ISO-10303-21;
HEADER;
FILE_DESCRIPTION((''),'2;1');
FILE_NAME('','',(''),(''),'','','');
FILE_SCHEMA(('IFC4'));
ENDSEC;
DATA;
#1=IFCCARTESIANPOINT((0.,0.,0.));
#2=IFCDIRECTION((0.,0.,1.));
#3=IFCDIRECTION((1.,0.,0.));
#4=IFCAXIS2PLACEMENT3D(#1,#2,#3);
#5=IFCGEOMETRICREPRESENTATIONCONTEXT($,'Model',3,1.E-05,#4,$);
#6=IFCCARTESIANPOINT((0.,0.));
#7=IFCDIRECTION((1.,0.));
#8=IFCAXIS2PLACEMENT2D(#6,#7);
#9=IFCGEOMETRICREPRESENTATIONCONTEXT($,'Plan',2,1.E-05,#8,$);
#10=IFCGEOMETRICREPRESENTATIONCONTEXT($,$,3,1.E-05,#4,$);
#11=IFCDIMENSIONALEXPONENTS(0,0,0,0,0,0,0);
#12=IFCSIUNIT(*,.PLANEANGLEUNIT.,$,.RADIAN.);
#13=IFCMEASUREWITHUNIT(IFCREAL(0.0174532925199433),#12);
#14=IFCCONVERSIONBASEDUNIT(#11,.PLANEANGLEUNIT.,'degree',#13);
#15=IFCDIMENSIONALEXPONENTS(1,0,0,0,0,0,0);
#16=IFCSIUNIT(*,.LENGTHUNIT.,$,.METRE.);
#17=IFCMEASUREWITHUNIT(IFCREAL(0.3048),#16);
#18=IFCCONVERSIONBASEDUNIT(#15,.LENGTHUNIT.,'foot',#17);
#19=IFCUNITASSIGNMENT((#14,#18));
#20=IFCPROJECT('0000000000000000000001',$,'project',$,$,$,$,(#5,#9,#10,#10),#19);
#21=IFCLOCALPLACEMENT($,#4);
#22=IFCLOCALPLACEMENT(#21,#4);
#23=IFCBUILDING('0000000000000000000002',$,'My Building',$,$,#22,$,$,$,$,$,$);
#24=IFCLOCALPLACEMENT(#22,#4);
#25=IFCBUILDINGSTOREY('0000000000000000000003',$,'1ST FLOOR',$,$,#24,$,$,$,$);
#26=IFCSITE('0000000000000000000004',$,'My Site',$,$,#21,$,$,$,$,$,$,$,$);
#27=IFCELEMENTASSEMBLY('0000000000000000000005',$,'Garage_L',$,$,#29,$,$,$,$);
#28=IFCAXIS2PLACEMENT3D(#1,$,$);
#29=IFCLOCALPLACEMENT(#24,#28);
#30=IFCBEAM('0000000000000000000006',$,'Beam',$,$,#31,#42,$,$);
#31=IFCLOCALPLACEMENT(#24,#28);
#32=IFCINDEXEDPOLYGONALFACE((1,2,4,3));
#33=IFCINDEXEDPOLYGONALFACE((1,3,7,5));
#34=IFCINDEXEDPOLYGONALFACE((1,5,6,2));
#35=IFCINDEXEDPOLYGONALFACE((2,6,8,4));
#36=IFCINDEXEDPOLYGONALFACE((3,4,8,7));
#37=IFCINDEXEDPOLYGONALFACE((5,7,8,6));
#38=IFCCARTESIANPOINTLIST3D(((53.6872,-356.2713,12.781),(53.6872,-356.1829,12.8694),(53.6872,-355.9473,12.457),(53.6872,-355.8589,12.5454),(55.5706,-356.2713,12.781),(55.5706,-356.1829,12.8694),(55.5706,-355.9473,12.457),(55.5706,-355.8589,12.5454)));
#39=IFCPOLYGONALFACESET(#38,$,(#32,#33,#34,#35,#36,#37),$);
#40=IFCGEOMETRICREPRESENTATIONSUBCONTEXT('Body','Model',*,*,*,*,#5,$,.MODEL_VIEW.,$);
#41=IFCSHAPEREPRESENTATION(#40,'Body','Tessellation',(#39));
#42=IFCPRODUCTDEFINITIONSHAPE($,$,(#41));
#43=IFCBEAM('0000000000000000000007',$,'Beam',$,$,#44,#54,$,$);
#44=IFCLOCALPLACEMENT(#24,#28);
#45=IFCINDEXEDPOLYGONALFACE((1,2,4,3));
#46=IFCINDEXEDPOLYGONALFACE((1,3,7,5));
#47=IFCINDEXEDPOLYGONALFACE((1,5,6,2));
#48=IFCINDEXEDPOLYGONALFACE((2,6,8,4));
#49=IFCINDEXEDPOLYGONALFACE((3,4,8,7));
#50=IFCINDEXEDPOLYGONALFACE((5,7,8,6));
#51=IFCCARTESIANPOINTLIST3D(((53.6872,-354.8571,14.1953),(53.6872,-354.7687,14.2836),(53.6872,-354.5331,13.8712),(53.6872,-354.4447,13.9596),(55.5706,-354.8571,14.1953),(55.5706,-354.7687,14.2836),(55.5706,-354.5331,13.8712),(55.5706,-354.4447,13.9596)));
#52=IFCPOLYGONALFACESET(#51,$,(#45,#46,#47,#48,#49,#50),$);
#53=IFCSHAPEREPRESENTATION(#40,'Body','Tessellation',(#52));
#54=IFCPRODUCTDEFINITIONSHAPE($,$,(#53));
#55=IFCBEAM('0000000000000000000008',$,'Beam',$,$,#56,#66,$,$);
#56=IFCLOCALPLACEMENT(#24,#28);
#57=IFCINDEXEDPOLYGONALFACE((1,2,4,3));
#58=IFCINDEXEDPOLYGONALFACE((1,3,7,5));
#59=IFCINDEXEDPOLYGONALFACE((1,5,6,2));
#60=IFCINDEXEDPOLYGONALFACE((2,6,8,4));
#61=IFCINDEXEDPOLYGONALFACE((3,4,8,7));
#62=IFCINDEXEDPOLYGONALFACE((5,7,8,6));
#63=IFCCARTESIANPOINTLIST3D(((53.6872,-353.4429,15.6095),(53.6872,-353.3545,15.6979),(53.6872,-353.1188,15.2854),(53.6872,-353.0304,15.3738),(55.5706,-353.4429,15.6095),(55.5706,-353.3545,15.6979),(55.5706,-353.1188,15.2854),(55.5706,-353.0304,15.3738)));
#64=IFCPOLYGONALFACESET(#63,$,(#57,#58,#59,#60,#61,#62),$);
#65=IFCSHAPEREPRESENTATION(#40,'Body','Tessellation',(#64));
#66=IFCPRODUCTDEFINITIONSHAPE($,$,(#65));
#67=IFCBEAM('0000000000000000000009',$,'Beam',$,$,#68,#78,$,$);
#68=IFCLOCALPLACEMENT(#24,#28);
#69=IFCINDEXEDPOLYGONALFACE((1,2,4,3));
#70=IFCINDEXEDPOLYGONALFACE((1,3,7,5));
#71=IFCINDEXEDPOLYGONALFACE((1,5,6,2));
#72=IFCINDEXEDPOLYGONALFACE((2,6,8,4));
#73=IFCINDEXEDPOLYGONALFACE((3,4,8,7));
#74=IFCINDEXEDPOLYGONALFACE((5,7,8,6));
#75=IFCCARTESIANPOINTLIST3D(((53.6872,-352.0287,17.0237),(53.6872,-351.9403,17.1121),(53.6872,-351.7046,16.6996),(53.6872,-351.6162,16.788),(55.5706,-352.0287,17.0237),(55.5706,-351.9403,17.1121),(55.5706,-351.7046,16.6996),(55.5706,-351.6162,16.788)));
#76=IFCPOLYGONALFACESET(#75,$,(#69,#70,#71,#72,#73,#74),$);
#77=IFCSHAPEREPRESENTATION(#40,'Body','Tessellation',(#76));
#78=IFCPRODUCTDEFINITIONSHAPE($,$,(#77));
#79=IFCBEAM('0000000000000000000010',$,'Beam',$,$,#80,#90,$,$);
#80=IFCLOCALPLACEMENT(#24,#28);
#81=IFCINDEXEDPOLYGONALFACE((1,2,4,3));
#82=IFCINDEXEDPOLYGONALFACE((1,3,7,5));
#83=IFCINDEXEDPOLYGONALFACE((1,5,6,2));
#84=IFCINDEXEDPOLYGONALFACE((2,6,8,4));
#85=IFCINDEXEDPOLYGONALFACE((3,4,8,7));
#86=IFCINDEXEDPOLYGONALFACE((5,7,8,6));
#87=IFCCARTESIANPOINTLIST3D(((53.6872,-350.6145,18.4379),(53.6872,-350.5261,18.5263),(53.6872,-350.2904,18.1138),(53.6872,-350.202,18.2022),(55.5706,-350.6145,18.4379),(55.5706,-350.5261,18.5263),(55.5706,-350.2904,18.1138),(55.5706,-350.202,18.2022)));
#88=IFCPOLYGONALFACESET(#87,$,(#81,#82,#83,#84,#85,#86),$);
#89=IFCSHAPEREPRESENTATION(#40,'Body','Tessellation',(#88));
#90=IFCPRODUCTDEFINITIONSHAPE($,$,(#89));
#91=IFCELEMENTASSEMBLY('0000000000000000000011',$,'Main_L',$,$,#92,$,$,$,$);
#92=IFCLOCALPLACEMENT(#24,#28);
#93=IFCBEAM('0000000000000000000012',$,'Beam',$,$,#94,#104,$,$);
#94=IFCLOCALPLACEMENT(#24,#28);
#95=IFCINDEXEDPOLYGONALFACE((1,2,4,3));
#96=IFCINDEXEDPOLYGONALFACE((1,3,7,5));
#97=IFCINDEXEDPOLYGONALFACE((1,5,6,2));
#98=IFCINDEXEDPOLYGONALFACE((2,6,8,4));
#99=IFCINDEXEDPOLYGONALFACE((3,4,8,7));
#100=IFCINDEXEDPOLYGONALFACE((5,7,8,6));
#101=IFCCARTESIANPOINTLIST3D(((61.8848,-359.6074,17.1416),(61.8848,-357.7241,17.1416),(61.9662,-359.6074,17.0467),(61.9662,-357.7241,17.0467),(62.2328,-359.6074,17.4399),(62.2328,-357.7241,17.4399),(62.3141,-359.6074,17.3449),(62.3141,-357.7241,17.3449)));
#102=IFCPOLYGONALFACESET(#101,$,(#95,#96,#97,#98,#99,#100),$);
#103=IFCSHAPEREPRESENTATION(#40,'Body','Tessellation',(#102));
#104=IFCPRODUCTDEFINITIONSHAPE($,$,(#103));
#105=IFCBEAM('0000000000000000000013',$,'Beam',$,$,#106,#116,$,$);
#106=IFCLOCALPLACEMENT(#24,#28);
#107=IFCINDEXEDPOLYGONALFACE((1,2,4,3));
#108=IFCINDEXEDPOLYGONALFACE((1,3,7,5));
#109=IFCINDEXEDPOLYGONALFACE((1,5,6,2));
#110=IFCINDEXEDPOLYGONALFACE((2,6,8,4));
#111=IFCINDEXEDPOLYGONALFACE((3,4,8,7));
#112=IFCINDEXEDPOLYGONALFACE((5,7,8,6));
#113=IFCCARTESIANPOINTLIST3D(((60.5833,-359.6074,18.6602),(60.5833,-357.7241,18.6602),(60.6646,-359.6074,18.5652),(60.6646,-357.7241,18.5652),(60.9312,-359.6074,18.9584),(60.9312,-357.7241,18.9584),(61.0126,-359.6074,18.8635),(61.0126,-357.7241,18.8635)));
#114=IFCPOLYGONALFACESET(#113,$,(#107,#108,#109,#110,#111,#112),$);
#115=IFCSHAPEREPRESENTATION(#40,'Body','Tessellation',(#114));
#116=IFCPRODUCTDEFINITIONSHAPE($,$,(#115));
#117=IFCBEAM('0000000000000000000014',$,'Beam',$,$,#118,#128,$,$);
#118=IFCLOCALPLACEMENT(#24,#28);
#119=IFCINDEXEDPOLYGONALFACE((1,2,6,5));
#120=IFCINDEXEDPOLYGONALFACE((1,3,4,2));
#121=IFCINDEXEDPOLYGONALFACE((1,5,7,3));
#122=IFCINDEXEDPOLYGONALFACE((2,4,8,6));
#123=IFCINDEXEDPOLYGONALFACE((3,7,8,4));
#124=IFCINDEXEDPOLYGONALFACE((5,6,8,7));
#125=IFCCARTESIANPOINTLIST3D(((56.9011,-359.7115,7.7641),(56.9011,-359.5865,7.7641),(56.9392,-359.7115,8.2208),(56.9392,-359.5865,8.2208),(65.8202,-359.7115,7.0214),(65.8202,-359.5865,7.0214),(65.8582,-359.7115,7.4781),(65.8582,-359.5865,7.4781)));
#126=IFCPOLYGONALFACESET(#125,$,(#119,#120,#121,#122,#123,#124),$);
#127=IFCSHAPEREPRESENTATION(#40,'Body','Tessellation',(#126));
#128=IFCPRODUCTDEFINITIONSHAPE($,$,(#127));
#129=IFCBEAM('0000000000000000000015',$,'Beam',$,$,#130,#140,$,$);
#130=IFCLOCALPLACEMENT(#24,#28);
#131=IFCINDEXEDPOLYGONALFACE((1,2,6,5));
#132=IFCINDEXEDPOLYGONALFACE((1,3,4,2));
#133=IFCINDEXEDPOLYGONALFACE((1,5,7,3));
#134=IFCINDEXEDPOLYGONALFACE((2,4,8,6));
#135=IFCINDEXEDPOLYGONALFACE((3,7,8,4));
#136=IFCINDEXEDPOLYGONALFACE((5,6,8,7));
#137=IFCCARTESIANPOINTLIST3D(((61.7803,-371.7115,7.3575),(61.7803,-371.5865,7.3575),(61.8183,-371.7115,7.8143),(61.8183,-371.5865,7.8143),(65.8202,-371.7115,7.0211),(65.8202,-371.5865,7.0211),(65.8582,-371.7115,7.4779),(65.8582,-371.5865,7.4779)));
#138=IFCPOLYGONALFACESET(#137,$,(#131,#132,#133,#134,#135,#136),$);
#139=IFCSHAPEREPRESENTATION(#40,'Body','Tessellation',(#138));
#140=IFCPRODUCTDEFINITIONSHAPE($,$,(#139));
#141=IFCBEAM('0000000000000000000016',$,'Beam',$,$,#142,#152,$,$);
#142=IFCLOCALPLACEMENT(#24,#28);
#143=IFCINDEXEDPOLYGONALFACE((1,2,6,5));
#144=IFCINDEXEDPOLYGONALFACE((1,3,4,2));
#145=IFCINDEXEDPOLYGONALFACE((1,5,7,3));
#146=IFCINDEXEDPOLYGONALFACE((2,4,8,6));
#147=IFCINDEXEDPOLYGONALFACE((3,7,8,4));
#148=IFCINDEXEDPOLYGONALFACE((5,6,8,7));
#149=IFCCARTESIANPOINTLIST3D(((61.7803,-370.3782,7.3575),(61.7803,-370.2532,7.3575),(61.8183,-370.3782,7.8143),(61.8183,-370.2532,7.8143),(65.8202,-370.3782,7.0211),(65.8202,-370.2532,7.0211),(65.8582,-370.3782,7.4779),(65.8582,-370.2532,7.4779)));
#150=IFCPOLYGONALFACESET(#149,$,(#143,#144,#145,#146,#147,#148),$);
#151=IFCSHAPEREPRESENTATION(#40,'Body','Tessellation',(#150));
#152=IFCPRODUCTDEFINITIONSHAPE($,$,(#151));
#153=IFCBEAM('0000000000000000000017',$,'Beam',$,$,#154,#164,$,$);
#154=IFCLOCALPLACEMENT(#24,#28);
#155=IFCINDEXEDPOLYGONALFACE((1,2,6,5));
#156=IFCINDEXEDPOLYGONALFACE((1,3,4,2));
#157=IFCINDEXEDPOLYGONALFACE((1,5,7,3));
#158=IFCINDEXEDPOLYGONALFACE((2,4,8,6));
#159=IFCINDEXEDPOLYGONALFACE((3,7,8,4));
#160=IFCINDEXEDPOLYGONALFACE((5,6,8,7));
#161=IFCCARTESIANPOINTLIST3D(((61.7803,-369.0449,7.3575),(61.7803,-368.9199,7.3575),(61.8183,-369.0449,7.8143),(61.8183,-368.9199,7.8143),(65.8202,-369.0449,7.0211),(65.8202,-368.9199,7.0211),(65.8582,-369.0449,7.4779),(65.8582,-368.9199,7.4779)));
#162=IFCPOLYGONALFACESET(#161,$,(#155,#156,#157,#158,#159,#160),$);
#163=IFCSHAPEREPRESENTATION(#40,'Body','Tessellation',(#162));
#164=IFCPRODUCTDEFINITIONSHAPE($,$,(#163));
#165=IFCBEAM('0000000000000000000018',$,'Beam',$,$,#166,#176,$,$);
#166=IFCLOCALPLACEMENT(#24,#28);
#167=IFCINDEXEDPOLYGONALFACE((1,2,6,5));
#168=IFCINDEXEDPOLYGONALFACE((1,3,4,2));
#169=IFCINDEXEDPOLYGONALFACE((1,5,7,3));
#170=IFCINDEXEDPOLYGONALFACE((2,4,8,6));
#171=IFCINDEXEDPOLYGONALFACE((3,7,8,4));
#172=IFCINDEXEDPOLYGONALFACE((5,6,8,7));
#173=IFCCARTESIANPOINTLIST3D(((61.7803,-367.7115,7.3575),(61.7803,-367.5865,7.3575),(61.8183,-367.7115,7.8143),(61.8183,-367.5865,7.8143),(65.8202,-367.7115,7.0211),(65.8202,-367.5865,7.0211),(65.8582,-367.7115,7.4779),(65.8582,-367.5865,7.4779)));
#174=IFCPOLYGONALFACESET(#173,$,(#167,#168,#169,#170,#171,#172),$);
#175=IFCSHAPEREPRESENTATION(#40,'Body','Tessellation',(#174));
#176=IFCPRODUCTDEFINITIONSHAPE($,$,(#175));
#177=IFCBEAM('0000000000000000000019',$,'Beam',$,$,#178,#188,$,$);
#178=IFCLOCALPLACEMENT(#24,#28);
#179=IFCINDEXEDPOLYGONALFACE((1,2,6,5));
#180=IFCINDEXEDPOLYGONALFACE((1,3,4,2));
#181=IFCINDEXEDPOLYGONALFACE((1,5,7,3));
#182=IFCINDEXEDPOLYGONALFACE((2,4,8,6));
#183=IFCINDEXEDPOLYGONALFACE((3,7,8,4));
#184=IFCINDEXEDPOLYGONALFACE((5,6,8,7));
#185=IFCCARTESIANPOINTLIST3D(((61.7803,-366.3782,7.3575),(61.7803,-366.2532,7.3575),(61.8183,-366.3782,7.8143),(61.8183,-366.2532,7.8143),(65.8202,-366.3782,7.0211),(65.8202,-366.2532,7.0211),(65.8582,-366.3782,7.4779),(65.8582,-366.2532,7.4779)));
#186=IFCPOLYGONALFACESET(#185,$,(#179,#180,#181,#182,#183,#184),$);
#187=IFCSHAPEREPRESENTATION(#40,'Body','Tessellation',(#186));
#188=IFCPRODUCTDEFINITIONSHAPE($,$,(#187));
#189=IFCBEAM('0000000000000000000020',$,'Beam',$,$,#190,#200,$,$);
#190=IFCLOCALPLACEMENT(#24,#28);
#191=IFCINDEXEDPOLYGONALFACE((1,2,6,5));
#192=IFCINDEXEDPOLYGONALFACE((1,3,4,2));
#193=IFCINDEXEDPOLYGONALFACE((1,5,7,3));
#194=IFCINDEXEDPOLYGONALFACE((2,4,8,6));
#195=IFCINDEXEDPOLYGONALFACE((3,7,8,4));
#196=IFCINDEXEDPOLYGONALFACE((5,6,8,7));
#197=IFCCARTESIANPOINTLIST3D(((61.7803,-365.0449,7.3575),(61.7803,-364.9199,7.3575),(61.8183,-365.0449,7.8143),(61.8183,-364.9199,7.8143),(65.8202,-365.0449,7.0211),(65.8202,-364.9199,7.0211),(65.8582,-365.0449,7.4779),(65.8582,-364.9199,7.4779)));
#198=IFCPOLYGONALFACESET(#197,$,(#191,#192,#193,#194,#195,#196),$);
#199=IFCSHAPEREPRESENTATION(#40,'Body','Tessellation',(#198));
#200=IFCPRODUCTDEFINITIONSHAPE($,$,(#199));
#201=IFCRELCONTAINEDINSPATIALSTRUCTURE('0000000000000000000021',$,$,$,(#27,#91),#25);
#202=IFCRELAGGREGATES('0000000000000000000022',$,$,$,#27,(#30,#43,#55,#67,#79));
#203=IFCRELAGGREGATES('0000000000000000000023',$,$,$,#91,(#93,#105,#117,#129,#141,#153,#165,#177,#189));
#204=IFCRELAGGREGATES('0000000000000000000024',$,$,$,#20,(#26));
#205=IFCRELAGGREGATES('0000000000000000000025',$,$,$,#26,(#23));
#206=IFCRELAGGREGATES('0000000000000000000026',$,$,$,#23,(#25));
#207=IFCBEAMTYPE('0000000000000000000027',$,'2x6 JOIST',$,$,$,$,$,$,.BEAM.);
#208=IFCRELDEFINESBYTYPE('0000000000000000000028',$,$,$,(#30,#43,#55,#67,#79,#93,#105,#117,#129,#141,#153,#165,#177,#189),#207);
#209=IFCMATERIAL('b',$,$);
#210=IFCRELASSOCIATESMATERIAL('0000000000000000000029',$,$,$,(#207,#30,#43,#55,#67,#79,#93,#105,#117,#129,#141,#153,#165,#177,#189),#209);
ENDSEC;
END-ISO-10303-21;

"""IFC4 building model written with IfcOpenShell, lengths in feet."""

from ifc_helpers import new_model, entity, si_unit, converted_unit, frame, origin_with_axes, origin_2d_with_axis, place, context, subcontext, project, spatial, rectangle, extrude, material, material_profile, profile_set, profile_usage, type_object, element, aggregate, save


model = new_model("IFC4")

# Units and contexts
model_context = context("Model", 3, precision=1e-05, world=origin_with_axes())
plan_context = context("Plan", 2, precision=1e-05, world=origin_2d_with_axis())
context_of_model = context(None, 3, precision=1e-05, world=origin_with_axes())
body_context = subcontext(model_context, "Body", "Model", "MODEL_VIEW")
ifc_project = project(units=[converted_unit("PLANEANGLEUNIT", "degree", entity("IfcReal", 0.0174532925199433), si_unit("PLANEANGLEUNIT", "RADIAN"), dimensions=[0, 0, 0, 0, 0, 0, 0]), converted_unit("LENGTHUNIT", "foot", entity("IfcReal", 0.3048), si_unit("LENGTHUNIT", "METRE"), dimensions=[1, 0, 0, 0, 0, 0, 0])], contexts=[model_context, plan_context, context_of_model, context_of_model])

# Site, building, storey
site_placement = place(None, origin_with_axes())
site = spatial("IfcSite", under=ifc_project, at=site_placement, Name="My Site")
building_placement = place(site_placement, origin_with_axes())
building = spatial("IfcBuilding", under=site, at=building_placement, Name="My Building")
storey_placement = place(building_placement, origin_with_axes())
storey = spatial("IfcBuildingStorey", under=building, at=storey_placement, Name="1ST FLOOR")

# Element assemblies, beams
assembly_1_placement = place(storey_placement, origin_with_axes())
assembly_1 = element("IfcElementAssembly", 1, at=assembly_1_placement, inside=storey, Name="Garage_L")
ifc_material_1 = material(Name="b")
ifc_material_profile_1 = material_profile(ifc_material_1, rectangle(XDim=0.125, YDim=0.4583))
ifc_profile_set_1 = profile_set([ifc_material_profile_1])
ifc_profile_usage_1 = profile_usage(ifc_profile_set_1, cardinal=8)
beam_type_1 = type_object("IfcBeamType", Name="2x6 JOIST", PredefinedType="BEAM", material=ifc_profile_set_1)
beam_1_placement = place(assembly_1_placement, frame((55.5706, -356.2271, 12.8252), z_axis=(-1.0, 0.0, 0.0), x_axis=(0.0, -0.707107, -0.707107)))
beam_1 = element("IfcBeam", 2, at=beam_1_placement, type_object=beam_type_1, material=ifc_profile_usage_1, Name="Beam", context=body_context, shape_type="SweptSolid", body=[
    extrude(rectangle(XDim=0.125, YDim=0.4583), frame((0.0, -0.2291, 0.0)), (0.0, 0.0, 1.0), 1.8833),
])
ifc_profile_usage_2 = profile_usage(ifc_profile_set_1, cardinal=8)
beam_2_placement = place(assembly_1_placement, frame((55.5706, -354.8129, 14.2394), z_axis=(-1.0, 0.0, 0.0), x_axis=(0.0, -0.707107, -0.707107)))
beam_2 = element("IfcBeam", 3, at=beam_2_placement, type_object=beam_type_1, material=ifc_profile_usage_2, Name="Beam", context=body_context, shape_type="SweptSolid", body=[
    extrude(rectangle(XDim=0.125, YDim=0.4583), frame((0.0, -0.2291, 0.0)), (0.0, 0.0, 1.0), 1.8833),
])
ifc_profile_usage_3 = profile_usage(ifc_profile_set_1, cardinal=8)
beam_3_placement = place(assembly_1_placement, frame((55.5706, -353.3987, 15.6537), z_axis=(-1.0, 0.0, 0.0), x_axis=(0.0, -0.707107, -0.707107)))
beam_3 = element("IfcBeam", 4, at=beam_3_placement, type_object=beam_type_1, material=ifc_profile_usage_3, Name="Beam", context=body_context, shape_type="SweptSolid", body=[
    extrude(rectangle(XDim=0.125, YDim=0.4583), frame((0.0, -0.2291, 0.0)), (0.0, 0.0, 1.0), 1.8833),
])
ifc_profile_usage_4 = profile_usage(ifc_profile_set_1, cardinal=8)
beam_4_placement = place(assembly_1_placement, frame((55.5706, -351.9845, 17.0679), z_axis=(-1.0, 0.0, 0.0), x_axis=(0.0, -0.707107, -0.707107)))
beam_4 = element("IfcBeam", 5, at=beam_4_placement, type_object=beam_type_1, material=ifc_profile_usage_4, Name="Beam", context=body_context, shape_type="SweptSolid", body=[
    extrude(rectangle(XDim=0.125, YDim=0.4583), frame((0.0, -0.2291, 0.0)), (0.0, 0.0, 1.0), 1.8833),
])
ifc_profile_usage_5 = profile_usage(ifc_profile_set_1, cardinal=8)
beam_5_placement = place(assembly_1_placement, frame((55.5706, -350.5703, 18.4821), z_axis=(-1.0, 0.0, 0.0), x_axis=(0.0, -0.707107, -0.707107)))
beam_5 = element("IfcBeam", 6, at=beam_5_placement, type_object=beam_type_1, material=ifc_profile_usage_5, Name="Beam", context=body_context, shape_type="SweptSolid", body=[
    extrude(rectangle(XDim=0.125, YDim=0.4583), frame((0.0, -0.2291, 0.0)), (0.0, 0.0, 1.0), 1.8833),
])
assembly_2_placement = place(storey_placement, origin_with_axes())
assembly_2 = element("IfcElementAssembly", 7, at=assembly_2_placement, inside=storey, Name="Main_L")
ifc_profile_usage_6 = profile_usage(ifc_profile_set_1, cardinal=8)
beam_6_placement = place(assembly_2_placement, frame((62.2735, -357.7241, 17.3924), z_axis=(0.0, -1.0, 0.0), x_axis=(0.650774, 0.0, -0.759271)))
beam_6 = element("IfcBeam", 8, at=beam_6_placement, type_object=beam_type_1, material=ifc_profile_usage_6, Name="Beam", context=body_context, shape_type="SweptSolid", body=[
    extrude(rectangle(XDim=0.125, YDim=0.4583), frame((0.0, -0.2291, 0.0)), (0.0, 0.0, 1.0), 1.8833),
])
ifc_profile_usage_7 = profile_usage(ifc_profile_set_1, cardinal=8)
beam_7_placement = place(assembly_2_placement, frame((60.9719, -357.7241, 18.9109), z_axis=(0.0, -1.0, 0.0), x_axis=(0.650774, 0.0, -0.759271)))
beam_7 = element("IfcBeam", 9, at=beam_7_placement, type_object=beam_type_1, material=ifc_profile_usage_7, Name="Beam", context=body_context, shape_type="SweptSolid", body=[
    extrude(rectangle(XDim=0.125, YDim=0.4583), frame((0.0, -0.2291, 0.0)), (0.0, 0.0, 1.0), 1.8833),
])
ifc_profile_usage_8 = profile_usage(ifc_profile_set_1)
beam_8_placement = place(assembly_2_placement, frame((56.9201, -359.649, 7.9924), z_axis=(0.996551, 0.0, -0.082982), x_axis=(0.0, 1.0, 0.0)))
beam_8 = element("IfcBeam", 10, at=beam_8_placement, type_object=beam_type_1, material=ifc_profile_usage_8, Name="Beam", context=body_context, shape_type="SweptSolid", body=[
    extrude(rectangle(XDim=0.125, YDim=0.4583), origin_with_axes(), (0.0, 0.0, 1.0), 8.9499),
])
ifc_profile_usage_9 = profile_usage(ifc_profile_set_1)
beam_9_placement = place(assembly_2_placement, frame((61.7993, -371.649, 7.5859), z_axis=(0.996551, 0.0, -0.082982), x_axis=(0.0, 1.0, 0.0)))
beam_9 = element("IfcBeam", 11, at=beam_9_placement, type_object=beam_type_1, material=ifc_profile_usage_9, Name="Beam", context=body_context, shape_type="SweptSolid", body=[
    extrude(rectangle(XDim=0.125, YDim=0.4583), origin_with_axes(), (0.0, 0.0, 1.0), 4.0539),
])
ifc_profile_usage_10 = profile_usage(ifc_profile_set_1)
beam_10_placement = place(assembly_2_placement, frame((61.7993, -370.3157, 7.5859), z_axis=(0.996551, 0.0, -0.082982), x_axis=(0.0, 1.0, 0.0)))
beam_10 = element("IfcBeam", 12, at=beam_10_placement, type_object=beam_type_1, material=ifc_profile_usage_10, Name="Beam", context=body_context, shape_type="SweptSolid", body=[
    extrude(rectangle(XDim=0.125, YDim=0.4583), origin_with_axes(), (0.0, 0.0, 1.0), 4.0539),
])
ifc_profile_usage_11 = profile_usage(ifc_profile_set_1)
beam_11_placement = place(assembly_2_placement, frame((61.7993, -368.9824, 7.5859), z_axis=(0.996551, 0.0, -0.082982), x_axis=(0.0, 1.0, 0.0)))
beam_11 = element("IfcBeam", 13, at=beam_11_placement, type_object=beam_type_1, material=ifc_profile_usage_11, Name="Beam", context=body_context, shape_type="SweptSolid", body=[
    extrude(rectangle(XDim=0.125, YDim=0.4583), origin_with_axes(), (0.0, 0.0, 1.0), 4.0539),
])
ifc_profile_usage_12 = profile_usage(ifc_profile_set_1)
beam_12_placement = place(assembly_2_placement, frame((61.7993, -367.649, 7.5859), z_axis=(0.996551, 0.0, -0.082982), x_axis=(0.0, 1.0, 0.0)))
beam_12 = element("IfcBeam", 14, at=beam_12_placement, type_object=beam_type_1, material=ifc_profile_usage_12, Name="Beam", context=body_context, shape_type="SweptSolid", body=[
    extrude(rectangle(XDim=0.125, YDim=0.4583), origin_with_axes(), (0.0, 0.0, 1.0), 4.0539),
])
ifc_profile_usage_13 = profile_usage(ifc_profile_set_1)
beam_13_placement = place(assembly_2_placement, frame((61.7993, -366.3157, 7.5859), z_axis=(0.996551, 0.0, -0.082982), x_axis=(0.0, 1.0, 0.0)))
beam_13 = element("IfcBeam", 15, at=beam_13_placement, type_object=beam_type_1, material=ifc_profile_usage_13, Name="Beam", context=body_context, shape_type="SweptSolid", body=[
    extrude(rectangle(XDim=0.125, YDim=0.4583), origin_with_axes(), (0.0, 0.0, 1.0), 4.0539),
])
ifc_profile_usage_14 = profile_usage(ifc_profile_set_1)
beam_14_placement = place(assembly_2_placement, frame((61.7993, -364.9824, 7.5859), z_axis=(0.996551, 0.0, -0.082982), x_axis=(0.0, 1.0, 0.0)))
beam_14 = element("IfcBeam", 16, at=beam_14_placement, type_object=beam_type_1, material=ifc_profile_usage_14, Name="Beam", context=body_context, shape_type="SweptSolid", body=[
    extrude(rectangle(XDim=0.125, YDim=0.4583), origin_with_axes(), (0.0, 0.0, 1.0), 4.0539),
])

aggregate(assembly_1, [beam_1, beam_2, beam_3, beam_4, beam_5])

aggregate(assembly_2, [beam_6, beam_7, beam_8, beam_9, beam_10, beam_11, beam_12, beam_13, beam_14])

save(model, "model.ifc")
